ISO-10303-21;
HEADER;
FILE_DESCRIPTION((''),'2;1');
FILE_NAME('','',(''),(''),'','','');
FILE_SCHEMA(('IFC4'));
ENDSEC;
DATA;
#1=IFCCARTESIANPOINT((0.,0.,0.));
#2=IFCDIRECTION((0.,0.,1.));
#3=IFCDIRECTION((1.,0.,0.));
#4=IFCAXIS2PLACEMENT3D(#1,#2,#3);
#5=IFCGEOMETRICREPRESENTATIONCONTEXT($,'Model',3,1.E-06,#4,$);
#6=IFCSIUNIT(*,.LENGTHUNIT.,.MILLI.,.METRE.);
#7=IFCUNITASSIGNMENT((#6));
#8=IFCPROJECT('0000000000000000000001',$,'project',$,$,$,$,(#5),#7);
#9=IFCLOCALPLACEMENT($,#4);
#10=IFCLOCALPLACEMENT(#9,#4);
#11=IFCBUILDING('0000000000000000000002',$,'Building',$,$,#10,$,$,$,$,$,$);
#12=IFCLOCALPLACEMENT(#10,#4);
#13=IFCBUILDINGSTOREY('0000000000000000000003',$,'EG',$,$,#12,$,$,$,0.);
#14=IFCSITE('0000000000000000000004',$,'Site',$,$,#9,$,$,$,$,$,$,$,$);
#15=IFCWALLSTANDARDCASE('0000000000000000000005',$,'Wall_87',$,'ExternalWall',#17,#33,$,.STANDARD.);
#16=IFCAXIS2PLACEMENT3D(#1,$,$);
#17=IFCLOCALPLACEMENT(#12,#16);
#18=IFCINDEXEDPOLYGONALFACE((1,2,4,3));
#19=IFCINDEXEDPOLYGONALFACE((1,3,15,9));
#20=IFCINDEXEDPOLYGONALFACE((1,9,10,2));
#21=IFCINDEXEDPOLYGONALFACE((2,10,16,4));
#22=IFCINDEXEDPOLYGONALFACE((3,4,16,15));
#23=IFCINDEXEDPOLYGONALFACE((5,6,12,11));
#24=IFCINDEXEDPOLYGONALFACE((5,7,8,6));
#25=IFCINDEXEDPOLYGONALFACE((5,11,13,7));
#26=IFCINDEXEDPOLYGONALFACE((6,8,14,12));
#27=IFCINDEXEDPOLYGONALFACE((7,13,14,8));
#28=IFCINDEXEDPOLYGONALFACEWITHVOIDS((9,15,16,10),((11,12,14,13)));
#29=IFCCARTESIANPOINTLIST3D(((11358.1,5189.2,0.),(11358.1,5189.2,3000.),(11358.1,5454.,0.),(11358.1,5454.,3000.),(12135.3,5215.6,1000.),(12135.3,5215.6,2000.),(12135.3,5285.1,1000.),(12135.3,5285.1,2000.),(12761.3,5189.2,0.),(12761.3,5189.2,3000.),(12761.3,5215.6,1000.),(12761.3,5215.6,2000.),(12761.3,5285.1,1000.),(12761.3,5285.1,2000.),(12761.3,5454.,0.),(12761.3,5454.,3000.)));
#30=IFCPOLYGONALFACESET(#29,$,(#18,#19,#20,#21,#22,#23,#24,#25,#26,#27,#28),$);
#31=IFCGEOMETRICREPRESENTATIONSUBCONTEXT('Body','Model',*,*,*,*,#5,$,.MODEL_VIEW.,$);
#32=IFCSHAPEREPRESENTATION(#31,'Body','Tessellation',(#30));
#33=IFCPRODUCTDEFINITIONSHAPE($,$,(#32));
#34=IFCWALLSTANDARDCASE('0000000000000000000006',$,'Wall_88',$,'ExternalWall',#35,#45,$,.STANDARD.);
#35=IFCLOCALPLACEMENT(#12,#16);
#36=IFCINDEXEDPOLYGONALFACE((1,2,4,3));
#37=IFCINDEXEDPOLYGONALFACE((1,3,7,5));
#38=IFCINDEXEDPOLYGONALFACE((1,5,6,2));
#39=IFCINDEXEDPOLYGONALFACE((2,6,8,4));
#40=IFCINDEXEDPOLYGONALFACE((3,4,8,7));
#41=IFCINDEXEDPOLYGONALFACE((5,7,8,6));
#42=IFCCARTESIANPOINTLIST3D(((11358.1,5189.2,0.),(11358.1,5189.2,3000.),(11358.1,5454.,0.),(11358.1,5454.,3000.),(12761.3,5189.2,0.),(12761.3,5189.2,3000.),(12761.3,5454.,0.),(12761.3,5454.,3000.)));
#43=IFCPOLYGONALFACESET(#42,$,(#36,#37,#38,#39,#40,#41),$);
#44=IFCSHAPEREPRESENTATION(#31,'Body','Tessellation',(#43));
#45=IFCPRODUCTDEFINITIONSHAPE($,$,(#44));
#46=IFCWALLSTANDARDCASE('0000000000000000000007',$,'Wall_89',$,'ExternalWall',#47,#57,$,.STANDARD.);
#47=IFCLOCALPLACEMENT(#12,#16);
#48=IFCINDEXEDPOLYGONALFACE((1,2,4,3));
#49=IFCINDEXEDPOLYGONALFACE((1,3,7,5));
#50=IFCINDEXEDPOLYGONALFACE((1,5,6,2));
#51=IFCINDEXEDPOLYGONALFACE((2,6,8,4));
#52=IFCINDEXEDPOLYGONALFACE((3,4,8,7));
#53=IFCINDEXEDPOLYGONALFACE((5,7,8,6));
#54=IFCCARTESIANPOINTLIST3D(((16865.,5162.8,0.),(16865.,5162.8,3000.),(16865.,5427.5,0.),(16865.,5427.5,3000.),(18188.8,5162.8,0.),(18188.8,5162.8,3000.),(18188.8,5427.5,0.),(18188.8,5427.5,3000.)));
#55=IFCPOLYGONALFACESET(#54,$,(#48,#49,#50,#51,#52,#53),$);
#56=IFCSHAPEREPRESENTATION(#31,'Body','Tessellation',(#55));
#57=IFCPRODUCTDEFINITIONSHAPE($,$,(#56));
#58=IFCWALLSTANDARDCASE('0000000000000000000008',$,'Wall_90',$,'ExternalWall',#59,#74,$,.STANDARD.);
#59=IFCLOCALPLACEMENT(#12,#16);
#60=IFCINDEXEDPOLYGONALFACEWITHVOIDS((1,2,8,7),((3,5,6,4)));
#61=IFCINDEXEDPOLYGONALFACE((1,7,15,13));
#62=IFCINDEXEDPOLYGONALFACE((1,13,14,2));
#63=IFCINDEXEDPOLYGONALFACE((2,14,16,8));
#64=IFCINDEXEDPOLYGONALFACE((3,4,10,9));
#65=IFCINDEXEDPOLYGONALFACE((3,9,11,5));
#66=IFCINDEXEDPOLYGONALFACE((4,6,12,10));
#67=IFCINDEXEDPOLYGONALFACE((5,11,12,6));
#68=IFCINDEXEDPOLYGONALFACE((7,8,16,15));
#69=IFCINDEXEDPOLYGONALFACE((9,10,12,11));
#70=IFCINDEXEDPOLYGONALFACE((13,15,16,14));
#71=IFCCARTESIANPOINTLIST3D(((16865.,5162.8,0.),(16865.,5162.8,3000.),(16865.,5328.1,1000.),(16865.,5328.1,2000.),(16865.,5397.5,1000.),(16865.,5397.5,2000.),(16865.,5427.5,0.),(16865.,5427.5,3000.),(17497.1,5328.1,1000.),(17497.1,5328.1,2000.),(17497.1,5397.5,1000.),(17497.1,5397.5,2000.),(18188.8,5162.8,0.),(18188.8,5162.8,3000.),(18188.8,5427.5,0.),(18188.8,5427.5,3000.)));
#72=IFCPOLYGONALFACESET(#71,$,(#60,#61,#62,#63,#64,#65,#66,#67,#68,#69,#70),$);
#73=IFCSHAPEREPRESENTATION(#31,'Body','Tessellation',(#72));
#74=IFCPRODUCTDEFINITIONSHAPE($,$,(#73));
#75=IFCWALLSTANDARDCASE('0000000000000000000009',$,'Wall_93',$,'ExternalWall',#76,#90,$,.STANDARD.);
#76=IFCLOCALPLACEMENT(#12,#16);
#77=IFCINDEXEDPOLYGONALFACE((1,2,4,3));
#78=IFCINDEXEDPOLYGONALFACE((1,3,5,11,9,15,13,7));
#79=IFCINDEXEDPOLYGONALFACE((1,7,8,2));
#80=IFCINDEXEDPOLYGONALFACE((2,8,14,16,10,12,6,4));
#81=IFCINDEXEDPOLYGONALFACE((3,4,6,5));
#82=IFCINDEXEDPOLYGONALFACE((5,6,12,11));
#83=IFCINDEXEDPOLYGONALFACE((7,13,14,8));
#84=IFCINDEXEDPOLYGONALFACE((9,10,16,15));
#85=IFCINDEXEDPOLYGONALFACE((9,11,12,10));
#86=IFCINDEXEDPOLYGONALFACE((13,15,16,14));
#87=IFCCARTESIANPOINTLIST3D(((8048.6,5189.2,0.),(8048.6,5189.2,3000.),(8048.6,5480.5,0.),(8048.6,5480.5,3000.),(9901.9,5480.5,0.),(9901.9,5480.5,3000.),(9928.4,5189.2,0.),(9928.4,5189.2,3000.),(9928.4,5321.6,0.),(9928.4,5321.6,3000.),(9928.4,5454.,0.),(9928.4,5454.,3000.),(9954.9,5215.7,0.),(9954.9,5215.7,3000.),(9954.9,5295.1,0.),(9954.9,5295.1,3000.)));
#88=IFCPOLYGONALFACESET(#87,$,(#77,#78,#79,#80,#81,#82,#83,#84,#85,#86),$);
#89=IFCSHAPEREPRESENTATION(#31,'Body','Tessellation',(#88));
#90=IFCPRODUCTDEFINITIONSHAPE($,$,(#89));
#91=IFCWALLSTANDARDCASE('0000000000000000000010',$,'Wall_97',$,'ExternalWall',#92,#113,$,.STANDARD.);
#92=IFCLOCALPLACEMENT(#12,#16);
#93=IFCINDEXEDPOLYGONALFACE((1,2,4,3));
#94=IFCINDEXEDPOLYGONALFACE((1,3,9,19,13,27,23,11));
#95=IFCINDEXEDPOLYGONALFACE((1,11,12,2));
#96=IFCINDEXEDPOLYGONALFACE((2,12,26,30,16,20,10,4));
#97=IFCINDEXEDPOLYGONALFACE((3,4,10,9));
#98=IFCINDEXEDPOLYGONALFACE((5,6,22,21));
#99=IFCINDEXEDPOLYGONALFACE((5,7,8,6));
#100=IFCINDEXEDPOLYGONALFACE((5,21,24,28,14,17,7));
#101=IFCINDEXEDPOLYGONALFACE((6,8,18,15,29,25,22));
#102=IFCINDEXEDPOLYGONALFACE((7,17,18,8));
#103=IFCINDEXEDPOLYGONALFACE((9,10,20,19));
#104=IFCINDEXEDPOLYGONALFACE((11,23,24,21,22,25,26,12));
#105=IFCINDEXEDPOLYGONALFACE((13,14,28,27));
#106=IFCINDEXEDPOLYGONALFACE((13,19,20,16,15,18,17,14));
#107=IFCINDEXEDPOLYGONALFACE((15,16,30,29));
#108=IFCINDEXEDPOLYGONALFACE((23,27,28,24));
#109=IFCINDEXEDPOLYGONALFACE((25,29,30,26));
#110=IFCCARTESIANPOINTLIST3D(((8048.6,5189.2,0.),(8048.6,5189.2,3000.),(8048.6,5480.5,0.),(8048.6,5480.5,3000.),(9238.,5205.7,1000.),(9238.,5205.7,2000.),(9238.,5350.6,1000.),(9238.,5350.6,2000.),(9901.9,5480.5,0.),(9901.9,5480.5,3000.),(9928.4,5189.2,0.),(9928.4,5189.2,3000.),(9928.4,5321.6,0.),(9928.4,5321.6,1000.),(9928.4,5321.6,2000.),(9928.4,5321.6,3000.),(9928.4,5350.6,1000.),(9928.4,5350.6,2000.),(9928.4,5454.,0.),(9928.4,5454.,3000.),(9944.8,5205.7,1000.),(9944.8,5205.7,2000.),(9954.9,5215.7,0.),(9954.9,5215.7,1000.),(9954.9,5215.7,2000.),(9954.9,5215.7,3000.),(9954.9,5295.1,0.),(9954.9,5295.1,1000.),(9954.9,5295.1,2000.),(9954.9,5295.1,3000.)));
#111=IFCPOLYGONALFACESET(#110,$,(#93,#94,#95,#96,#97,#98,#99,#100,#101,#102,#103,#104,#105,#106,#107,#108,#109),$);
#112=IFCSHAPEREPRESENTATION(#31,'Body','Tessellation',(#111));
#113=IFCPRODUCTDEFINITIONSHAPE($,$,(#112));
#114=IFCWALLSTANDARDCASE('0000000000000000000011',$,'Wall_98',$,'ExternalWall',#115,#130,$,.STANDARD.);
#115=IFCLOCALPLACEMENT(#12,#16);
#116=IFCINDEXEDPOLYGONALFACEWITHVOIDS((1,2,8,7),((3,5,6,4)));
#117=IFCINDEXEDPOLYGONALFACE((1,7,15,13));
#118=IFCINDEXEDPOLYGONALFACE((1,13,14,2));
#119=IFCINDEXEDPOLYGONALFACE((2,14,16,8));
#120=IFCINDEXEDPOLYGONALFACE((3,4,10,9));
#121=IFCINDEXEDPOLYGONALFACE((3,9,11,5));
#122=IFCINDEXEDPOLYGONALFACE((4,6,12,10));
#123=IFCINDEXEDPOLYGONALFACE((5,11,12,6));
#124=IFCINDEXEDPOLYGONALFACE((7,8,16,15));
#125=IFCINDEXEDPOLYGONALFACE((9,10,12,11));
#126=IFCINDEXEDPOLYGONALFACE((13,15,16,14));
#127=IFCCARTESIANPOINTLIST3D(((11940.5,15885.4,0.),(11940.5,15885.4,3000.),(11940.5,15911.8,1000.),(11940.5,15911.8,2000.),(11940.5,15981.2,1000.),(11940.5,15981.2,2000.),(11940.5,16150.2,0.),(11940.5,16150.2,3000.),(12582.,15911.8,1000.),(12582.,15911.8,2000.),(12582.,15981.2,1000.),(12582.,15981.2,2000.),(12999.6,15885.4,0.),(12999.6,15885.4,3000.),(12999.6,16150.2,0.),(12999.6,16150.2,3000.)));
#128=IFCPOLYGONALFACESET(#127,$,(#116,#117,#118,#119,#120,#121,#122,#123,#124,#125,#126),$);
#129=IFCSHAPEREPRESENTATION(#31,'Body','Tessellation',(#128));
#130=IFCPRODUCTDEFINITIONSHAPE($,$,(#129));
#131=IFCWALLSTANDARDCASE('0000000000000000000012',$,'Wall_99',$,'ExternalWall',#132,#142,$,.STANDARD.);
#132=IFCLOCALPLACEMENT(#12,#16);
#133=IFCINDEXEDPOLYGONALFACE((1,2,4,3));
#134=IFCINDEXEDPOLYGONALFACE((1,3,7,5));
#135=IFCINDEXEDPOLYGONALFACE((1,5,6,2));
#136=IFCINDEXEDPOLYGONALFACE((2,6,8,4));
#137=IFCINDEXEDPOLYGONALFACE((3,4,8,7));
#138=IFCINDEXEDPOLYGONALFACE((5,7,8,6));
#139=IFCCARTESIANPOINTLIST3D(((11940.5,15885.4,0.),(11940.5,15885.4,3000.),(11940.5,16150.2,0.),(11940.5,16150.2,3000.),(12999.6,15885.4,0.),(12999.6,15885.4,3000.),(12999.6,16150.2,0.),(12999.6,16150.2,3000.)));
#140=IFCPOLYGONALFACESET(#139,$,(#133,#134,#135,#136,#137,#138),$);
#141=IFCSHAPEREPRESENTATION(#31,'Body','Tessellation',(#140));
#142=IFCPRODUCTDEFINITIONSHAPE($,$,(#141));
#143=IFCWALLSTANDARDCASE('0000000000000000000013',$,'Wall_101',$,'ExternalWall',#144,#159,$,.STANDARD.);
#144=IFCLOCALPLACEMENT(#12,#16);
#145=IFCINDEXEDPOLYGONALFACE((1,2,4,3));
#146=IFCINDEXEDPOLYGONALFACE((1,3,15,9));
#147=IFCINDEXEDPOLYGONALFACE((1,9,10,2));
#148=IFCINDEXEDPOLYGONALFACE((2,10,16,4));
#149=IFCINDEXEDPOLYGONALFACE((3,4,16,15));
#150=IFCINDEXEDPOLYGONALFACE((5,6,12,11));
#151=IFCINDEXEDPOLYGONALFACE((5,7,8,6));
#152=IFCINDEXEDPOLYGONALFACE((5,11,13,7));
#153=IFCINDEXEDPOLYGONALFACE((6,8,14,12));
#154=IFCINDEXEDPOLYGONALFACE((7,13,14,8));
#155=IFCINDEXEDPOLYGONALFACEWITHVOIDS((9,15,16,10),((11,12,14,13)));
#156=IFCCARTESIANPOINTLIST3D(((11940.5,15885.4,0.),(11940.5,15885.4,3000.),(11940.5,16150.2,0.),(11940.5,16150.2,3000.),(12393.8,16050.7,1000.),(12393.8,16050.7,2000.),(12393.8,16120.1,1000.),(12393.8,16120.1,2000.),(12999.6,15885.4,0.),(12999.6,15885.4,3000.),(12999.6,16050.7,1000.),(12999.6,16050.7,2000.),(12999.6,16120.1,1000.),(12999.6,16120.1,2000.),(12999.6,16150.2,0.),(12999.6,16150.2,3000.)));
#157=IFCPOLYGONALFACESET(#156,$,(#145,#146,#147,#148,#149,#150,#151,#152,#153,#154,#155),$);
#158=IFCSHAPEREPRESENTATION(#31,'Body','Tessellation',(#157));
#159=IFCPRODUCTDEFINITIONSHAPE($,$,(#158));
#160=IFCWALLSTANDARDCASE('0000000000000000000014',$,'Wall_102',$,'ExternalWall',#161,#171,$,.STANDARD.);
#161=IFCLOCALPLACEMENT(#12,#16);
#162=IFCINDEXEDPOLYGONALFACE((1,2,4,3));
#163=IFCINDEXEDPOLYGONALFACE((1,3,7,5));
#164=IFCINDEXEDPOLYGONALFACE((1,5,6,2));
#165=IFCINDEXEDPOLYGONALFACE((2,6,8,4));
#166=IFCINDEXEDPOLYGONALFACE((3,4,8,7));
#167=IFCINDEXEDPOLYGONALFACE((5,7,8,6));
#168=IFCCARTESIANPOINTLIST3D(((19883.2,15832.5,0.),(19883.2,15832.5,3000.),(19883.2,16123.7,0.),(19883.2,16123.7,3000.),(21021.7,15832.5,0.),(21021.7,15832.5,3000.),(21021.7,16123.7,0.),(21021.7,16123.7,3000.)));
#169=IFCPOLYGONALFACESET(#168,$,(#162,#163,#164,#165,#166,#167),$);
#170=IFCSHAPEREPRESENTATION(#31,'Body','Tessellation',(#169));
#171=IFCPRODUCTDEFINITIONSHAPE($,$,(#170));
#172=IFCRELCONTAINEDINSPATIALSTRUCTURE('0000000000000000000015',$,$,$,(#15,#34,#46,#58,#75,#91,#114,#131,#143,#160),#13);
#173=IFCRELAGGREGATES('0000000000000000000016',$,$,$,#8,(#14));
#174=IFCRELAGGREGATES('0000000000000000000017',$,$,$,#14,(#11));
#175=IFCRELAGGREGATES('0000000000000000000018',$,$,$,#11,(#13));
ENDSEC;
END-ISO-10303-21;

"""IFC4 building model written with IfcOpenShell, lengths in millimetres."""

from ifc_helpers import new_model, si_unit, frame, origin_with_axes, place, context, subcontext, project, spatial, polyline, rectangle, outline, extrude, element, save


model = new_model("IFC4")

# Units and contexts
model_context = context("Model", 3, precision=1e-06, world=origin_with_axes())
body_context = subcontext(model_context, "Body", "Model", "MODEL_VIEW")
ifc_project = project(units=[si_unit("LENGTHUNIT", "METRE", prefix="MILLI")], contexts=[model_context])

# Site, building, storey
site_placement = place(None, origin_with_axes())
site = spatial("IfcSite", under=ifc_project, at=site_placement, Name="Site")
building_placement = place(site_placement, origin_with_axes())
building = spatial("IfcBuilding", under=site, at=building_placement, Name="Building")
storey_placement = place(building_placement, origin_with_axes())
storey = spatial("IfcBuildingStorey", under=building, at=storey_placement, Name="EG", Elevation=0.0)

# Wall, opening
wall_1_placement = place(storey_placement, origin_with_axes())
wall_1 = element("IfcWallStandardCase", 1, at=wall_1_placement, inside=storey, Name="Wall_87", ObjectType="ExternalWall", PredefinedType="STANDARD", context=body_context, shape_type="SweptSolid", body=[
    extrude(outline(polyline([(11358.1, 5189.2, 0.0), (11358.1, 5454.0, 0.0), (12761.3, 5454.0, 0.0), (12761.3, 5189.2, 0.0), (11358.1, 5189.2, 0.0)])), origin_with_axes(), (0.0, 0.0, 1.0), 3000.0),
])
opening_1_placement = place(wall_1_placement, origin_with_axes())
element("IfcOpeningElement", 2, at=opening_1_placement, inside=storey, cuts=wall_1, context=body_context, shape_type="SweptSolid", body=[
    extrude(rectangle(XDim=1123.3, YDim=69.4), frame((12697.0, 5250.3, 1000.0), z_axis=(0.0, 0.0, 1.0), x_axis=(1.0, 0.0, 0.0)), (0.0, 0.0, 1.0), 1000.0),
])

# Walls
wall_2_placement = place(storey_placement, origin_with_axes())
element("IfcWallStandardCase", 3, at=wall_2_placement, inside=storey, Name="Wall_88", ObjectType="ExternalWall", PredefinedType="STANDARD", context=body_context, shape_type="SweptSolid", body=[
    extrude(outline(polyline([(11358.1, 5189.2, 0.0), (11358.1, 5454.0, 0.0), (12761.3, 5454.0, 0.0), (12761.3, 5189.2, 0.0), (11358.1, 5189.2, 0.0)])), origin_with_axes(), (0.0, 0.0, 1.0), 3000.0),
])
wall_3_placement = place(storey_placement, origin_with_axes())
element("IfcWallStandardCase", 4, at=wall_3_placement, inside=storey, Name="Wall_89", ObjectType="ExternalWall", PredefinedType="STANDARD", context=body_context, shape_type="SweptSolid", body=[
    extrude(outline(polyline([(16865.0, 5162.8, 0.0), (16865.0, 5427.5, 0.0), (18188.8, 5427.5, 0.0), (18188.8, 5162.8, 0.0), (16865.0, 5162.8, 0.0)])), origin_with_axes(), (0.0, 0.0, 1.0), 3000.0),
])

# Wall, opening
wall_4_placement = place(storey_placement, origin_with_axes())
wall_4 = element("IfcWallStandardCase", 5, at=wall_4_placement, inside=storey, Name="Wall_90", ObjectType="ExternalWall", PredefinedType="STANDARD", context=body_context, shape_type="SweptSolid", body=[
    extrude(outline(polyline([(16865.0, 5162.8, 0.0), (16865.0, 5427.5, 0.0), (18188.8, 5427.5, 0.0), (18188.8, 5162.8, 0.0), (16865.0, 5162.8, 0.0)])), origin_with_axes(), (0.0, 0.0, 1.0), 3000.0),
])
opening_2_placement = place(wall_4_placement, origin_with_axes())
element("IfcOpeningElement", 6, at=opening_2_placement, inside=storey, cuts=wall_4, context=body_context, shape_type="SweptSolid", body=[
    extrude(rectangle(XDim=1142.0, YDim=69.4), frame((16926.1, 5362.8, 1000.0), z_axis=(0.0, 0.0, 1.0), x_axis=(1.0, 0.0, 0.0)), (0.0, 0.0, 1.0), 1000.0),
])

# Wall
for number, where, z_axis, x_axis, name in (
    (7, (0.0, 0.0, 0.0), (0.0, 0.0, 1.0), (1.0, 0.0, 0.0), "Wall_93"),
):
    element("IfcWallStandardCase", number, at=place(storey_placement, frame(where, z_axis=z_axis, x_axis=x_axis)), inside=storey, Name=name, ObjectType="ExternalWall", PredefinedType="STANDARD", context=body_context, shape_type="SweptSolid", body=[
        extrude(outline(polyline([(8048.6, 5189.2, 0.0), (8048.6, 5480.5, 0.0), (9901.9, 5480.5, 0.0), (9928.4, 5454.0, 0.0), (9928.4, 5321.6, 0.0), (9954.9, 5295.1, 0.0), (9954.9, 5215.7, 0.0), (9928.4, 5189.2, 0.0), (8048.6, 5189.2, 0.0)])), origin_with_axes(), (0.0, 0.0, 1.0), 3000.0),
    ])

# Walls, openings
wall_5_placement = place(storey_placement, origin_with_axes())
wall_5 = element("IfcWallStandardCase", 8, at=wall_5_placement, inside=storey, Name="Wall_97", ObjectType="ExternalWall", PredefinedType="STANDARD", context=body_context, shape_type="SweptSolid", body=[
    extrude(outline(polyline([(8048.6, 5189.2, 0.0), (8048.6, 5480.5, 0.0), (9901.9, 5480.5, 0.0), (9928.4, 5454.0, 0.0), (9928.4, 5321.6, 0.0), (9954.9, 5295.1, 0.0), (9954.9, 5215.7, 0.0), (9928.4, 5189.2, 0.0), (8048.6, 5189.2, 0.0)])), origin_with_axes(), (0.0, 0.0, 1.0), 3000.0),
])
opening_3_placement = place(wall_5_placement, origin_with_axes())
element("IfcOpeningElement", 9, at=opening_3_placement, inside=storey, cuts=wall_5, context=body_context, shape_type="SweptSolid", body=[
    extrude(rectangle(XDim=1215.6, YDim=144.9), frame((9845.8, 5278.1, 1000.0), z_axis=(0.0, 0.0, 1.0), x_axis=(1.0, 0.0, 0.0)), (0.0, 0.0, 1.0), 1000.0),
])
wall_6_placement = place(storey_placement, origin_with_axes())
wall_6 = element("IfcWallStandardCase", 10, at=wall_6_placement, inside=storey, Name="Wall_98", ObjectType="ExternalWall", PredefinedType="STANDARD", context=body_context, shape_type="SweptSolid", body=[
    extrude(outline(polyline([(11940.5, 15885.4, 0.0), (11940.5, 16150.2, 0.0), (12999.6, 16150.2, 0.0), (12999.6, 15885.4, 0.0), (11940.5, 15885.4, 0.0)])), origin_with_axes(), (0.0, 0.0, 1.0), 3000.0),
])
opening_4_placement = place(wall_6_placement, origin_with_axes())
element("IfcOpeningElement", 11, at=opening_4_placement, inside=storey, cuts=wall_6, context=body_context, shape_type="SweptSolid", body=[
    extrude(rectangle(XDim=1160.7, YDim=69.4), frame((12001.7, 15946.5, 1000.0), z_axis=(0.0, 0.0, 1.0), x_axis=(1.0, 0.0, 0.0)), (0.0, 0.0, 1.0), 1000.0),
])

# Wall
for number, where, z_axis, x_axis, name in (
    (12, (0.0, 0.0, 0.0), (0.0, 0.0, 1.0), (1.0, 0.0, 0.0), "Wall_99"),
):
    element("IfcWallStandardCase", number, at=place(storey_placement, frame(where, z_axis=z_axis, x_axis=x_axis)), inside=storey, Name=name, ObjectType="ExternalWall", PredefinedType="STANDARD", context=body_context, shape_type="SweptSolid", body=[
        extrude(outline(polyline([(11940.5, 15885.4, 0.0), (11940.5, 16150.2, 0.0), (12999.6, 16150.2, 0.0), (12999.6, 15885.4, 0.0), (11940.5, 15885.4, 0.0)])), origin_with_axes(), (0.0, 0.0, 1.0), 3000.0),
    ])

# Wall, opening
wall_7_placement = place(storey_placement, origin_with_axes())
wall_7 = element("IfcWallStandardCase", 13, at=wall_7_placement, inside=storey, Name="Wall_101", ObjectType="ExternalWall", PredefinedType="STANDARD", context=body_context, shape_type="SweptSolid", body=[
    extrude(outline(polyline([(11940.5, 15885.4, 0.0), (11940.5, 16150.2, 0.0), (12999.6, 16150.2, 0.0), (12999.6, 15885.4, 0.0), (11940.5, 15885.4, 0.0)])), origin_with_axes(), (0.0, 0.0, 1.0), 3000.0),
])
opening_5_placement = place(wall_7_placement, origin_with_axes())
element("IfcOpeningElement", 14, at=opening_5_placement, inside=storey, cuts=wall_7, context=body_context, shape_type="SweptSolid", body=[
    extrude(rectangle(XDim=1104.5, YDim=69.4), frame((12946.1, 16085.4, 1000.0), z_axis=(0.0, 0.0, 1.0), x_axis=(1.0, 0.0, 0.0)), (0.0, 0.0, 1.0), 1000.0),
])

# Wall
for number, where, z_axis, x_axis, name in (
    (15, (0.0, 0.0, 0.0), (0.0, 0.0, 1.0), (1.0, 0.0, 0.0), "Wall_102"),
):
    element("IfcWallStandardCase", number, at=place(storey_placement, frame(where, z_axis=z_axis, x_axis=x_axis)), inside=storey, Name=name, ObjectType="ExternalWall", PredefinedType="STANDARD", context=body_context, shape_type="SweptSolid", body=[
        extrude(outline(polyline([(19883.2, 15832.5, 0.0), (19883.2, 16123.7, 0.0), (21021.7, 16123.7, 0.0), (21021.7, 15832.5, 0.0), (19883.2, 15832.5, 0.0)])), origin_with_axes(), (0.0, 0.0, 1.0), 3000.0),
    ])

save(model, "model.ifc")
